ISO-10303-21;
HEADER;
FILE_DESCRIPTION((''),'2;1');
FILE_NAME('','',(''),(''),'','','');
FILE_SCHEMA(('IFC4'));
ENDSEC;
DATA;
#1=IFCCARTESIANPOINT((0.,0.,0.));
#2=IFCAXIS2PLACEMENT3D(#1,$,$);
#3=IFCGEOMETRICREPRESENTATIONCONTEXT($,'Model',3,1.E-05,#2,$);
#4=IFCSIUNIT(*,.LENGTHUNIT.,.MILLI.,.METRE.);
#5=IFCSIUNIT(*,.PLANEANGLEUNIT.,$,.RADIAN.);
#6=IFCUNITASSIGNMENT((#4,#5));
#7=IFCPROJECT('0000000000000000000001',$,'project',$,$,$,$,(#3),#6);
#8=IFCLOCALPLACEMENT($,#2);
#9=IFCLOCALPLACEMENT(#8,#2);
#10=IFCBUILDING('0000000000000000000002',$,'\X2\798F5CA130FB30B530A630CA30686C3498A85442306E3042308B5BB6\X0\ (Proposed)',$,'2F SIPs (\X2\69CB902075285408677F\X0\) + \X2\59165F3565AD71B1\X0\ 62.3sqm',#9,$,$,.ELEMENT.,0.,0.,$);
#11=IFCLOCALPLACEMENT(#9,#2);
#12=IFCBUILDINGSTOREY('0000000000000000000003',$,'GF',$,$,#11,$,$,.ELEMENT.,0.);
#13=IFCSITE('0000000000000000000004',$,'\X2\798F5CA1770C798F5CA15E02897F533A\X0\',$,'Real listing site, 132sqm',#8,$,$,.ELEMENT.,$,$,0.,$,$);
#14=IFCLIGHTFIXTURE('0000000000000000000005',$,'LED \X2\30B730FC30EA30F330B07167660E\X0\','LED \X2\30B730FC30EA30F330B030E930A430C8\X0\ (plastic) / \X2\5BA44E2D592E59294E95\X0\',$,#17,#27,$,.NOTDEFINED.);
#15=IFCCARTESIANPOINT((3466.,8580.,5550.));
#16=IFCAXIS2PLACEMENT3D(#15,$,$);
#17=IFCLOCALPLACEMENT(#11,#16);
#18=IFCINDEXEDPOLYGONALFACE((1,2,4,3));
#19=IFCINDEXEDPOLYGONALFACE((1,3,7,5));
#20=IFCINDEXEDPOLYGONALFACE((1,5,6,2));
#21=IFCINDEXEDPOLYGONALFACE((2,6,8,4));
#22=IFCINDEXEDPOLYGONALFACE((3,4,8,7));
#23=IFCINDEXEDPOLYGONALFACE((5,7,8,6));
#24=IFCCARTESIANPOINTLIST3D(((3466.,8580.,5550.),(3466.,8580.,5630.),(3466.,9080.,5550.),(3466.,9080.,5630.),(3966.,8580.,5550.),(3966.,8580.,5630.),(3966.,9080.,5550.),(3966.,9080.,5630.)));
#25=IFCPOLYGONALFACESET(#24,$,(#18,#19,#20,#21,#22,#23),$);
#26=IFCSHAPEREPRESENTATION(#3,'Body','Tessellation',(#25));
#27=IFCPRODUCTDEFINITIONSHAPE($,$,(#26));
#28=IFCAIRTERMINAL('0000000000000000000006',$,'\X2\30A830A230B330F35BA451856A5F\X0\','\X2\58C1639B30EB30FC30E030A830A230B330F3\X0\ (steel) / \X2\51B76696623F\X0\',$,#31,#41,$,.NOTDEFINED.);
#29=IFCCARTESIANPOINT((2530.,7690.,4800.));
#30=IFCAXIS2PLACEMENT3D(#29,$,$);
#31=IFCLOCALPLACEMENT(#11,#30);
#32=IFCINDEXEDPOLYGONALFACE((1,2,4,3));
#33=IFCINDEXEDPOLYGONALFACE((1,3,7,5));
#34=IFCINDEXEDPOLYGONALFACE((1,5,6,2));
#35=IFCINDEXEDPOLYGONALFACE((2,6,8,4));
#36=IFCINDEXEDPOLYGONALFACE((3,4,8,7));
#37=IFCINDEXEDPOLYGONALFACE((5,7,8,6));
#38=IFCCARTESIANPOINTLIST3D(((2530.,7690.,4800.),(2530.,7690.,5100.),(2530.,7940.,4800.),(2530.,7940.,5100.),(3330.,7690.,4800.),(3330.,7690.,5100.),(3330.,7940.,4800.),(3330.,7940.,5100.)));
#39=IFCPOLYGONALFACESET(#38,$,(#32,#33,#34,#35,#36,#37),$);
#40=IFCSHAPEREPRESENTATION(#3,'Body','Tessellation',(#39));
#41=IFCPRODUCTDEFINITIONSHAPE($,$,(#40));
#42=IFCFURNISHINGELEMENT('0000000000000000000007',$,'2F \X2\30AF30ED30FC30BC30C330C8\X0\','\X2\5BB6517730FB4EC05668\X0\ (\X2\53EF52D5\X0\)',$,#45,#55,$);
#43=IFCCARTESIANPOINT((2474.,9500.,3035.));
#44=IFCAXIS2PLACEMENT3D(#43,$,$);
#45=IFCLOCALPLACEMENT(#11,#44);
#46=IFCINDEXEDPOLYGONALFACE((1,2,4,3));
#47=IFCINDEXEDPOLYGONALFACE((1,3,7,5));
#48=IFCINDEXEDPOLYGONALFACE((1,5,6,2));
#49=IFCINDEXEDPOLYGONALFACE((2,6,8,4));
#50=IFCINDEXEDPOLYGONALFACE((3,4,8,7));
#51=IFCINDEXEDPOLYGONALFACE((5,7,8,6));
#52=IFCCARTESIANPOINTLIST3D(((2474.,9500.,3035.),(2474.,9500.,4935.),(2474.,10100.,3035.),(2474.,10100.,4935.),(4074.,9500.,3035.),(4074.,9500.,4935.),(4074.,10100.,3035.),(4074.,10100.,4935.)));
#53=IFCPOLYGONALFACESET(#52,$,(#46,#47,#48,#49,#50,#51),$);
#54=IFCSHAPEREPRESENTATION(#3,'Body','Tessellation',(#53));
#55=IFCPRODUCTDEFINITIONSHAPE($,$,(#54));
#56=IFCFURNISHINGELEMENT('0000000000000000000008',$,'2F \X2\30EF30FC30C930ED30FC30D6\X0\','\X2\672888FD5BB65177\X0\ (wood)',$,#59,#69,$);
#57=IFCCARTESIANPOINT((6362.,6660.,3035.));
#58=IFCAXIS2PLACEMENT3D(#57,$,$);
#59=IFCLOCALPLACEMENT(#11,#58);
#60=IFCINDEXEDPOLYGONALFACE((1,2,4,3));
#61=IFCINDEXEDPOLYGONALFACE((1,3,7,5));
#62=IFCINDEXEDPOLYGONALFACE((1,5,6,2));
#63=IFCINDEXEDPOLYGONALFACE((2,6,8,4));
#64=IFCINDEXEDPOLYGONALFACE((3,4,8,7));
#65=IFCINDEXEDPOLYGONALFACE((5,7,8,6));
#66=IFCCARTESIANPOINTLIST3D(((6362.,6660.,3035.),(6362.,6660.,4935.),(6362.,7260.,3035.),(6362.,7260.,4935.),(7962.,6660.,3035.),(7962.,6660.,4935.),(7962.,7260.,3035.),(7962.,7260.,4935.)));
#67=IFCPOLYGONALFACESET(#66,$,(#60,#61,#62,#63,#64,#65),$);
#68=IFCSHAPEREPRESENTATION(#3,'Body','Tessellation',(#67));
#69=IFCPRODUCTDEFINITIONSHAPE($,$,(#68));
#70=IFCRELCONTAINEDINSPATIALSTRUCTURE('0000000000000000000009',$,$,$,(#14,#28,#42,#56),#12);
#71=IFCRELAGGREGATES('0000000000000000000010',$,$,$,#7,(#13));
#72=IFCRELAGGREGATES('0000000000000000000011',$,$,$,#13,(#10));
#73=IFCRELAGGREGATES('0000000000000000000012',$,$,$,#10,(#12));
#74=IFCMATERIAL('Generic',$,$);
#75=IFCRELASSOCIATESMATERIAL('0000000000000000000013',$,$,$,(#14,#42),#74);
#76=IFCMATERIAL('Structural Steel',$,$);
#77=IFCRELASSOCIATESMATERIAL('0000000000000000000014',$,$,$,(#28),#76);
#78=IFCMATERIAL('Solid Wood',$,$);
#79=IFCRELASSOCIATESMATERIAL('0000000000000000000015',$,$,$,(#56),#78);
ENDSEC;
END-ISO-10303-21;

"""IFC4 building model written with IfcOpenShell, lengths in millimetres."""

from ifc_helpers import new_model, si_unit, frame, frame_2d, origin, place, context, project, spatial, rectangle, extrude, material, element, save


model = new_model("IFC4")

# Units and contexts
model_context = context("Model", 3, precision=1e-05, world=origin())
ifc_project = project(units=[si_unit("LENGTHUNIT", "METRE", prefix="MILLI"), si_unit("PLANEANGLEUNIT", "RADIAN")], contexts=[model_context])

# Site, building, storey
site_placement = place(None, origin())
site = spatial("IfcSite", under=ifc_project, at=site_placement, Name="福岡県福岡市西区", ObjectType="Real listing site, 132sqm", CompositionType="ELEMENT", RefElevation=0.0)
building_placement = place(site_placement, origin())
building = spatial("IfcBuilding", under=site, at=building_placement, Name="福岡・サウナと水風呂のある家 (Proposed)", ObjectType="2F SIPs (構造用合板) + 外張断熱 62.3sqm", CompositionType="ELEMENT", ElevationOfRefHeight=0.0, ElevationOfTerrain=0.0)
storey_placement = place(building_placement, origin())
storey = spatial("IfcBuildingStorey", under=building, at=storey_placement, Name="GF", CompositionType="ELEMENT", Elevation=0.0)

# Shared definitions
ifc_material_1 = material(Name="Solid Wood")

# Shared definitions
ifc_material_2 = material(Name="Generic")

# Shared definitions
ifc_material_3 = material(Name="Structural Steel")

# Light fixture
light_fixture_1_placement = place(storey_placement, frame((3466.0, 8580.0, 5550.0)))
element("IfcLightFixture", 1, at=light_fixture_1_placement, inside=storey, material=ifc_material_2, Name="LED シーリング照明", Description="LED シーリングライト (plastic) / 室中央天井", PredefinedType="NOTDEFINED", context=model_context, shape_type="SweptSolid", body=[
    extrude(rectangle(XDim=500.0, YDim=500.0, at=frame_2d((250.0, 250.0))), frame((3466.0, 8580.0, 5550.0)), (0.0, 0.0, 1.0), 80.0),
])

# Air terminal
air_terminal_placement = place(storey_placement, frame((2530.0, 7690.0, 4800.0)))
element("IfcAirTerminal", 2, at=air_terminal_placement, inside=storey, material=ifc_material_3, Name="エアコン室内機", Description="壁掛ルームエアコン (steel) / 冷暖房", PredefinedType="NOTDEFINED", context=model_context, shape_type="SweptSolid", body=[
    extrude(rectangle(XDim=800.0, YDim=250.0, at=frame_2d((400.0, 125.0))), frame((2530.0, 7690.0, 4800.0)), (0.0, 0.0, 1.0), 300.0),
])

# Furnishing elements
furnishing_1_placement = place(storey_placement, frame((2474.0, 9500.0, 3035.0)))
element("IfcFurnishingElement", 3, at=furnishing_1_placement, inside=storey, material=ifc_material_2, Name="2F クローゼット", Description="家具・什器 (可動)", context=model_context, shape_type="SweptSolid", body=[
    extrude(rectangle(XDim=1600.0, YDim=600.0, at=frame_2d((800.0, 300.0))), frame((2474.0, 9500.0, 3035.0)), (0.0, 0.0, 1.0), 1900.0),
])
furnishing_2_placement = place(storey_placement, frame((6362.0, 6660.0, 3035.0)))
element("IfcFurnishingElement", 4, at=furnishing_2_placement, inside=storey, material=ifc_material_1, Name="2F ワードローブ", Description="木製家具 (wood)", context=model_context, shape_type="SweptSolid", body=[
    extrude(rectangle(XDim=1600.0, YDim=600.0, at=frame_2d((800.0, 300.0))), frame((6362.0, 6660.0, 3035.0)), (0.0, 0.0, 1.0), 1900.0),
])

save(model, "model.ifc")
